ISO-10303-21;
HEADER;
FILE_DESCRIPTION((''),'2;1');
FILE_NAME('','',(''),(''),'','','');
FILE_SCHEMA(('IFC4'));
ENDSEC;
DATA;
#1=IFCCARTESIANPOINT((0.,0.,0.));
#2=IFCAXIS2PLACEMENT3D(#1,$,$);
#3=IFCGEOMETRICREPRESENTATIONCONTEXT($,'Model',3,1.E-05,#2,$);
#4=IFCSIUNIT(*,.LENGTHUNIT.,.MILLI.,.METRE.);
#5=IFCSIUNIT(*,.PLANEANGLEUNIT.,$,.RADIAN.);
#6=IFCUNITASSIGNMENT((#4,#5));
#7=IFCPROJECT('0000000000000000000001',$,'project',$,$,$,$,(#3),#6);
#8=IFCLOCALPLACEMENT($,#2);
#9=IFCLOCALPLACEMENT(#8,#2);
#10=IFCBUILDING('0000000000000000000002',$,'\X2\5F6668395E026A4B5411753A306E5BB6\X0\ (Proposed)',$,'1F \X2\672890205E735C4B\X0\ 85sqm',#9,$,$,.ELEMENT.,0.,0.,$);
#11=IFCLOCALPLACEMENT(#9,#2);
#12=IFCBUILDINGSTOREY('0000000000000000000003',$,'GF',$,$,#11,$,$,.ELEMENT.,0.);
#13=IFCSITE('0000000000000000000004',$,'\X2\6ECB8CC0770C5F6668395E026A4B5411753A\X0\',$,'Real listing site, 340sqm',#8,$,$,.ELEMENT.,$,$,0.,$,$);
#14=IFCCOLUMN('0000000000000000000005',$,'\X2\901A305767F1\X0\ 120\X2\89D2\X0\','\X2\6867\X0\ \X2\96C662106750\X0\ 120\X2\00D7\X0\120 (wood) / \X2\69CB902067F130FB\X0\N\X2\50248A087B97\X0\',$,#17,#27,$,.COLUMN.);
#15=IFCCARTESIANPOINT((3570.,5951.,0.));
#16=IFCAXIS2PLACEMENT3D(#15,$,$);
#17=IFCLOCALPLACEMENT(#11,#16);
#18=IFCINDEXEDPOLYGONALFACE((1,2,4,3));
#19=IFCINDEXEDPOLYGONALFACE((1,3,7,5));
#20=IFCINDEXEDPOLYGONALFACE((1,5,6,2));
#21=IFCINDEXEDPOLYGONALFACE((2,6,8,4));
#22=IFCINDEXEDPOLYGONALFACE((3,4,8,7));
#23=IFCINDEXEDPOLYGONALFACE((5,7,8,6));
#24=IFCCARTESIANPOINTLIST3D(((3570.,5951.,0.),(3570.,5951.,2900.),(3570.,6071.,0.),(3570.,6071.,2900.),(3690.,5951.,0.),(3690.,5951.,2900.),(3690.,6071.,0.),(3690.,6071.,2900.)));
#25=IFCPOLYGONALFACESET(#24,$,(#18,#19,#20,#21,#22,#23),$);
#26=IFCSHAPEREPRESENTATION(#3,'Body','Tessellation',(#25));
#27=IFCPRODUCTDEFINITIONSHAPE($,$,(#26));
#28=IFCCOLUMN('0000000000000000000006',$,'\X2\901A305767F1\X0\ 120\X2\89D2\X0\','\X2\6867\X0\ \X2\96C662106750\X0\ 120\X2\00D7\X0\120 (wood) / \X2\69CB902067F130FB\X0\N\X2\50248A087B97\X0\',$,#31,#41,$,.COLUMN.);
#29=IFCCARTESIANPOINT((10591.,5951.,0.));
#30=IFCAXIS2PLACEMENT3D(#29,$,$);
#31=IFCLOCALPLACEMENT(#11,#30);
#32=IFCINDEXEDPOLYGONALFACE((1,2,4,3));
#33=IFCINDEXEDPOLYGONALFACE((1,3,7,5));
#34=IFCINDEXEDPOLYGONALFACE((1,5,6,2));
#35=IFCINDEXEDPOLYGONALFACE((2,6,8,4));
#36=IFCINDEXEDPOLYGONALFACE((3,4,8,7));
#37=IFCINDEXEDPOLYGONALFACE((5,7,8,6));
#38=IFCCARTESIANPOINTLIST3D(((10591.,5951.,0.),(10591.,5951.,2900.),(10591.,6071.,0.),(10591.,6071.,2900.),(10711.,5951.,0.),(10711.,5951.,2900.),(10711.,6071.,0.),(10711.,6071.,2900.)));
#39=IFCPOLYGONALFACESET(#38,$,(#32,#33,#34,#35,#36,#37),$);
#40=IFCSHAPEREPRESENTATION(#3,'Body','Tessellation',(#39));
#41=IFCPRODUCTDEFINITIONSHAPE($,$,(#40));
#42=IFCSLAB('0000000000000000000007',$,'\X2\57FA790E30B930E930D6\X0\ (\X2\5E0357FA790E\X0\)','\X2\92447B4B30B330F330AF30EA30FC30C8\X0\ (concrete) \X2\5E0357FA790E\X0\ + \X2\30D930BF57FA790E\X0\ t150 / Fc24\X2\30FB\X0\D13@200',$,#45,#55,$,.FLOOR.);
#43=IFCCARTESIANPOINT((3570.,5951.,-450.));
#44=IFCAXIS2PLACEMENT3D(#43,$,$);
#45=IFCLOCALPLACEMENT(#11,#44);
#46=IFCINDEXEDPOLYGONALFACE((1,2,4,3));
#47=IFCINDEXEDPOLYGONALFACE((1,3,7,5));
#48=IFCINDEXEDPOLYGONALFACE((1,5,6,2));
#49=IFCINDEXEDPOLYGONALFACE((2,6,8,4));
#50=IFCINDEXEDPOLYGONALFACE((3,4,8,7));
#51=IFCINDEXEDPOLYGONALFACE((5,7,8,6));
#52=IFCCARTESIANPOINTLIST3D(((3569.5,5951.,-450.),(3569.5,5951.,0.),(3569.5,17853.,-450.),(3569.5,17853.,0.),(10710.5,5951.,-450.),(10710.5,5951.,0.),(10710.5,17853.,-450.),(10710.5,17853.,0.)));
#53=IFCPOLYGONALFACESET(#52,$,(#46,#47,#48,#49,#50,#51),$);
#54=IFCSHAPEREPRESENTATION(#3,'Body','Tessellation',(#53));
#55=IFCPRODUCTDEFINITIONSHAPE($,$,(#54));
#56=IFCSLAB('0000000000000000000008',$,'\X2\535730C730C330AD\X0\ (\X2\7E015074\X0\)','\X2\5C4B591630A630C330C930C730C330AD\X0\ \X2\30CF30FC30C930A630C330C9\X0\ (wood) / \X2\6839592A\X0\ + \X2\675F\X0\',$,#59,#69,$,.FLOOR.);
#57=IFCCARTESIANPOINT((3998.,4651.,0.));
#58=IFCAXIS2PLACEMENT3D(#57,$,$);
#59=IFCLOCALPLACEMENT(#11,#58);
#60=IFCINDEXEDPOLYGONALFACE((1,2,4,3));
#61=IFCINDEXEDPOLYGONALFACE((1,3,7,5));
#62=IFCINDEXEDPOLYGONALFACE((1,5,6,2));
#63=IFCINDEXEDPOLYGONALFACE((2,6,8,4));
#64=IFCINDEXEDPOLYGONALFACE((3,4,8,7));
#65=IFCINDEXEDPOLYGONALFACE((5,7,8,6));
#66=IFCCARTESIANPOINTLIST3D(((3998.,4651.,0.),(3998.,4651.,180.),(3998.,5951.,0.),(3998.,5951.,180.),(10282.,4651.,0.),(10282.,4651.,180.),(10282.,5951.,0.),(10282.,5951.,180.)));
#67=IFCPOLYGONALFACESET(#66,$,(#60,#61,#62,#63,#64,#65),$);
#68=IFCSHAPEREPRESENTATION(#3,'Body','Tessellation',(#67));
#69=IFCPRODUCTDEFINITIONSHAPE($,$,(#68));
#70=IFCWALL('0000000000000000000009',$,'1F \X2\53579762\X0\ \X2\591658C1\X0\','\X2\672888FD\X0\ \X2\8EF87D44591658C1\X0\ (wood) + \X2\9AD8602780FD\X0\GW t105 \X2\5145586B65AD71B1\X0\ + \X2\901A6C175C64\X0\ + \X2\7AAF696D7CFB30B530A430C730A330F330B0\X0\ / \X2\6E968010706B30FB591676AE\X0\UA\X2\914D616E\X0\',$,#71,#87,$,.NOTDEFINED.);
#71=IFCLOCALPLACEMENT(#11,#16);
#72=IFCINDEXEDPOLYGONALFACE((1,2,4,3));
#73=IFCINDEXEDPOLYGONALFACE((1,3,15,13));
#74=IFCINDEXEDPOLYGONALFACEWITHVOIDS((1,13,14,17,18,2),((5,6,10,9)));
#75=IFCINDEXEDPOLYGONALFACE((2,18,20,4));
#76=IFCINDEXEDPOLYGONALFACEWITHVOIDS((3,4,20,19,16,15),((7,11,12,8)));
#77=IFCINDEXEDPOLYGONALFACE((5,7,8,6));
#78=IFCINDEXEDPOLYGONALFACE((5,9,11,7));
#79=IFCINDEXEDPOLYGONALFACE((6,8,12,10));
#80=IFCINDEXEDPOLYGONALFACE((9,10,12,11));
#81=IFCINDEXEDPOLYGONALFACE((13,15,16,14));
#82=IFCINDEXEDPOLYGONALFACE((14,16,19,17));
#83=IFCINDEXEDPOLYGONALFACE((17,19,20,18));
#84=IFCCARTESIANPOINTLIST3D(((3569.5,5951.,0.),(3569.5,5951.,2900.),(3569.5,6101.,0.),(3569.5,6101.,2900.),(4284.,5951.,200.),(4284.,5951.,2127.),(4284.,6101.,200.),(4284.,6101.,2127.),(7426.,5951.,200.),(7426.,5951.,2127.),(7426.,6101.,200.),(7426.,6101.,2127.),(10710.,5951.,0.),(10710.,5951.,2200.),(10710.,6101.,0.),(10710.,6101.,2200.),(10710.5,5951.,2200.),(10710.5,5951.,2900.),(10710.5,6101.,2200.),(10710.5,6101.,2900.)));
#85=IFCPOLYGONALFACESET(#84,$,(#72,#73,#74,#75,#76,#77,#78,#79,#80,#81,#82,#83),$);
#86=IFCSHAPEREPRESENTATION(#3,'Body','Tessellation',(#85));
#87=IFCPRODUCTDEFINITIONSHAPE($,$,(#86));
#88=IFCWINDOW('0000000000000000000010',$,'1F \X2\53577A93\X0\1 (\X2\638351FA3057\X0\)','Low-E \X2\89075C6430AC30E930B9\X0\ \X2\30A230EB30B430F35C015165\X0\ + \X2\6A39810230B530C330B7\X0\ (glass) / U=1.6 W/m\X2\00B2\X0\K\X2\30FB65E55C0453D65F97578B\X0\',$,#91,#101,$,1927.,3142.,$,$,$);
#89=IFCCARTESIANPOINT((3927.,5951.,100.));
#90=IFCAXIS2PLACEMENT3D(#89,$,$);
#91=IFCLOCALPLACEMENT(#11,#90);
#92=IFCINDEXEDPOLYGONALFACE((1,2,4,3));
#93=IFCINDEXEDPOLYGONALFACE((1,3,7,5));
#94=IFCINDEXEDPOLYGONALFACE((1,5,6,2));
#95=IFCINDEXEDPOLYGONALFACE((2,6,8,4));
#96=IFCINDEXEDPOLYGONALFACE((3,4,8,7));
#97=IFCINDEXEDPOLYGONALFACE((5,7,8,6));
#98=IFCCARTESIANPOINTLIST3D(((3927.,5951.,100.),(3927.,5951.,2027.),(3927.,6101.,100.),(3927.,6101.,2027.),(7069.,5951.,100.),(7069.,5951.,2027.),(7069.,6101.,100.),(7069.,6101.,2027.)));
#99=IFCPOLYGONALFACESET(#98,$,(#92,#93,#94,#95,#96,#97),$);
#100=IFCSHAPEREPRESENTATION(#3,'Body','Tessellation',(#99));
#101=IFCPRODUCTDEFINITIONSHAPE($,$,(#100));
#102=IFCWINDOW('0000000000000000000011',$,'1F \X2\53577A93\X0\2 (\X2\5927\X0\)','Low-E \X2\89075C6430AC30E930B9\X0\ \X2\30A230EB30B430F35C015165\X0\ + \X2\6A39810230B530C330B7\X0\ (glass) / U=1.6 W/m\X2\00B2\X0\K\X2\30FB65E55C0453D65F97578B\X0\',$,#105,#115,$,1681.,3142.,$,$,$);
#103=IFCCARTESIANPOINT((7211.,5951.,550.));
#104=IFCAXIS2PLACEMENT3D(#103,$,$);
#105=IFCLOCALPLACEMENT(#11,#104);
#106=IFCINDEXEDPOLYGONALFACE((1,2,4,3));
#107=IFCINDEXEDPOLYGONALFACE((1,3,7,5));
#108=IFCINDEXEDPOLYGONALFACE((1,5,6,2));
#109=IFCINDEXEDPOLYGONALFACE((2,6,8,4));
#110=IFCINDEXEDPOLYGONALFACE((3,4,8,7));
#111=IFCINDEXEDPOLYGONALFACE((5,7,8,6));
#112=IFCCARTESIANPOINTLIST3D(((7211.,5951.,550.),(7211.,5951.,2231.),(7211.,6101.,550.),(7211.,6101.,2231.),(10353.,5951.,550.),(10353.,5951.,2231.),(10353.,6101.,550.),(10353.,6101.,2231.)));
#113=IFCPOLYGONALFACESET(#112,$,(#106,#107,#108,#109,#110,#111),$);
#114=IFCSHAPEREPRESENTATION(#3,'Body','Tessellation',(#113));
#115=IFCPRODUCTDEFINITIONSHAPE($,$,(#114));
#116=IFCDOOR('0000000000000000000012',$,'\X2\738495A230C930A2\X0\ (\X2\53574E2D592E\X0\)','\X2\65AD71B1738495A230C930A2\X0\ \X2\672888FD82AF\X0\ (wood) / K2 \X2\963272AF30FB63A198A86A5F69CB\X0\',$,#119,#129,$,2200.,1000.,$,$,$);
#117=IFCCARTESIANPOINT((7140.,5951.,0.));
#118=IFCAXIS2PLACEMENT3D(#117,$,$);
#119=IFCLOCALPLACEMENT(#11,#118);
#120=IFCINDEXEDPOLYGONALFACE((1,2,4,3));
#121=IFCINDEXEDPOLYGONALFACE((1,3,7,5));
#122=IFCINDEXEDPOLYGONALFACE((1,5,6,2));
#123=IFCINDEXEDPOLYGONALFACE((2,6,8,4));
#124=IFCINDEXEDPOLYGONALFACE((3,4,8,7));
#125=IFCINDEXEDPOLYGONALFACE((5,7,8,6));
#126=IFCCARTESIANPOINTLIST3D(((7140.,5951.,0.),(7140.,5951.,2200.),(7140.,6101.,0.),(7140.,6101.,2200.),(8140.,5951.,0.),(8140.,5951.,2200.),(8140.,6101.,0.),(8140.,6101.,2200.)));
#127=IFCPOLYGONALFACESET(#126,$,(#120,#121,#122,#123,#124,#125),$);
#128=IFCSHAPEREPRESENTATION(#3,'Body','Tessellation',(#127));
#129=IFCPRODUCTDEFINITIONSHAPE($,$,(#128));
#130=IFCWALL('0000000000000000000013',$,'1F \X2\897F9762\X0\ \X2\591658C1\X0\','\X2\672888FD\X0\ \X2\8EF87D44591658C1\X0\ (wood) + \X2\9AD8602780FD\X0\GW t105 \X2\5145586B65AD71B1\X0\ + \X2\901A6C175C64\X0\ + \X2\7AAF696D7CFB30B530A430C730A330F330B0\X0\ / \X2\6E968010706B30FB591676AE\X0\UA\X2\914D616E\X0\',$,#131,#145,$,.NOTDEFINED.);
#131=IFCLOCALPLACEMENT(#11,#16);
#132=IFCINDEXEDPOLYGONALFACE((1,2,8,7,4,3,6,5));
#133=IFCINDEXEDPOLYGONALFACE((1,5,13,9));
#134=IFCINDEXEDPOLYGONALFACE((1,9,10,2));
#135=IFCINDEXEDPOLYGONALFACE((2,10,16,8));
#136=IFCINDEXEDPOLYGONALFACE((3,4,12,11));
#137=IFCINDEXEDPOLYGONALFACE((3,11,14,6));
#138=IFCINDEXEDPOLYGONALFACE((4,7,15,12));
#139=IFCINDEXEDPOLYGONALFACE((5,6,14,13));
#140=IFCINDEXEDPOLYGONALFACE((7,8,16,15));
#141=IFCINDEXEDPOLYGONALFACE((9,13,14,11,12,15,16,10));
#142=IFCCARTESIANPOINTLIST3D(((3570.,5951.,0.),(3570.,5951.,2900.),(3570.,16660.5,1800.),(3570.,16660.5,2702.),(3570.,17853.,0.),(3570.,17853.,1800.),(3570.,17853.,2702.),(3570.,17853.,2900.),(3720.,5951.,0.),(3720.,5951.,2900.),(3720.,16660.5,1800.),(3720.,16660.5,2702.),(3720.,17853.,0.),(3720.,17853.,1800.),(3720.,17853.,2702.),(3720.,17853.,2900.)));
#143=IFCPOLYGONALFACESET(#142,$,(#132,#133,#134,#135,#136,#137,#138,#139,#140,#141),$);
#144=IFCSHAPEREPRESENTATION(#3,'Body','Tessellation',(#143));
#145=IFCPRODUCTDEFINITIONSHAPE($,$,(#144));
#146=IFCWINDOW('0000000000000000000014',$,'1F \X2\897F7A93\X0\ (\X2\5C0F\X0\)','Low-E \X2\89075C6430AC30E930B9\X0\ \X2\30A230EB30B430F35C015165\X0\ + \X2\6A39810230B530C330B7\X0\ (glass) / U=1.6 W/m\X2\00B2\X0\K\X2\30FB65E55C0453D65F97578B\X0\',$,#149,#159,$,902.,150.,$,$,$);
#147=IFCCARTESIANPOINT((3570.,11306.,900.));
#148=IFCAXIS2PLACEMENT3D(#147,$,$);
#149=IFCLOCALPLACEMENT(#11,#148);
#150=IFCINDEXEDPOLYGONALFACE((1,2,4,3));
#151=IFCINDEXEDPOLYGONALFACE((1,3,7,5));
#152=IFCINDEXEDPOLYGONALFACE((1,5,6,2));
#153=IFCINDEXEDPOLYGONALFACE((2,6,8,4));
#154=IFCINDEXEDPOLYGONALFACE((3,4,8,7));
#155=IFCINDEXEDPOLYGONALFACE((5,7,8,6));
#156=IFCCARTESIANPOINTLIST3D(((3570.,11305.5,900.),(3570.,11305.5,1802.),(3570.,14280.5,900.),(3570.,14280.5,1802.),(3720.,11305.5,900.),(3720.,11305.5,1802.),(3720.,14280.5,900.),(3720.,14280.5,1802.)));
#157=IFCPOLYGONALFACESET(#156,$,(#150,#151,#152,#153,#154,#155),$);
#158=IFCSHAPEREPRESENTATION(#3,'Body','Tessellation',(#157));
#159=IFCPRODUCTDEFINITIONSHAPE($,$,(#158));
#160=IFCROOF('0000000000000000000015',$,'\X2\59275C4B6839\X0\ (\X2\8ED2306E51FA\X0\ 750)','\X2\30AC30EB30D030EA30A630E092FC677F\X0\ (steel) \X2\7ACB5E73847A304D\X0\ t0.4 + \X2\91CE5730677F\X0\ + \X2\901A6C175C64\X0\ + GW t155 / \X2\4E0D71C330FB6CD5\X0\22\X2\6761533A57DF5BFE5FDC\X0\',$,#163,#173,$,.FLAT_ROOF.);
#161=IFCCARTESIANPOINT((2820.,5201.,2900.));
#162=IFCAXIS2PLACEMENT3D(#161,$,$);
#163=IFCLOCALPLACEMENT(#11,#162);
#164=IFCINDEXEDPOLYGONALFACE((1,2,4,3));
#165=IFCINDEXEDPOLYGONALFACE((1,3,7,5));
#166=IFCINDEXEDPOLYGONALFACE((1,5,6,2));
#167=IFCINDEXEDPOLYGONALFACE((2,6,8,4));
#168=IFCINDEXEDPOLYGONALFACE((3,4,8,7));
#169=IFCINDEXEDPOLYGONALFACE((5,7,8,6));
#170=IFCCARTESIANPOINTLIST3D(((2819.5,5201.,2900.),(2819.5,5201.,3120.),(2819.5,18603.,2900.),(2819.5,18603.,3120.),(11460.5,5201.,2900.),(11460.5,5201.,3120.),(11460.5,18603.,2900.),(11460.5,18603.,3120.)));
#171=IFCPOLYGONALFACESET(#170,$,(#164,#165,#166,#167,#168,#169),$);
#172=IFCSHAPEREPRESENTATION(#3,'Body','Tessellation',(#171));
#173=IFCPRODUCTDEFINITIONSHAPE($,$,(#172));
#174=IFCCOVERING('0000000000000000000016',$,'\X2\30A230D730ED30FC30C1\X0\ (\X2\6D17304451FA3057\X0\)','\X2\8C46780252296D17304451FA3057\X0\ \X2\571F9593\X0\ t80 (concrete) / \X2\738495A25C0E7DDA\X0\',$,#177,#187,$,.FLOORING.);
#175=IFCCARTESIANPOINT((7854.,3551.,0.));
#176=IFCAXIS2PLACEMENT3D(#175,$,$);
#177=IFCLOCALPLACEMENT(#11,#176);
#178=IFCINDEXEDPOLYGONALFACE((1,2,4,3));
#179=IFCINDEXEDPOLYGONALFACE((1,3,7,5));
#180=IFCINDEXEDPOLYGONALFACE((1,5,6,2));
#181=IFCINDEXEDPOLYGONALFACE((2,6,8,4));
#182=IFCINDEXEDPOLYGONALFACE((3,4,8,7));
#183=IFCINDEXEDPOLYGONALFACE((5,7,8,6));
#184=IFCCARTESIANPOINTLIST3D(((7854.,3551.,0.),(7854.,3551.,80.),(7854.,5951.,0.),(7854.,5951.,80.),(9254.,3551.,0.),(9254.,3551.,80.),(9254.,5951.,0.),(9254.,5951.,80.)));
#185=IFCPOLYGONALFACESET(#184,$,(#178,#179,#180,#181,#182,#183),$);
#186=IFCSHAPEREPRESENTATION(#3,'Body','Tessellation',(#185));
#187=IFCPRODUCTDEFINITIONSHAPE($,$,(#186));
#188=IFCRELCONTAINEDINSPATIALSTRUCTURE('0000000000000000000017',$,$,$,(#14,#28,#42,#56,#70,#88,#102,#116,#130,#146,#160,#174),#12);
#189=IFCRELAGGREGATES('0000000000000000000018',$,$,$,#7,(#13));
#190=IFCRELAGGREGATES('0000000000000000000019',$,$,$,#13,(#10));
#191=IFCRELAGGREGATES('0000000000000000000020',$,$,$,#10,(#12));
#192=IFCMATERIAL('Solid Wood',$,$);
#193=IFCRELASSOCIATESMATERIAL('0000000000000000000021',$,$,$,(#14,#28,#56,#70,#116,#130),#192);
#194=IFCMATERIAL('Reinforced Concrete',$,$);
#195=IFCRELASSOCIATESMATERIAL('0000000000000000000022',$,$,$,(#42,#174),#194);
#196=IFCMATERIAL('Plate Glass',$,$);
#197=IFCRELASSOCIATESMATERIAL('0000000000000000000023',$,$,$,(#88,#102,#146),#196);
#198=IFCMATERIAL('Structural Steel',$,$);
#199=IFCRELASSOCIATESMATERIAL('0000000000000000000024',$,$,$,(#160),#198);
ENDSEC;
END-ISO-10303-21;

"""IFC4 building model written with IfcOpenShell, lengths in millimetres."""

from ifc_helpers import new_model, si_unit, frame, frame_2d, origin, place, context, project, spatial, rectangle, extrude, material, element, fill, save


model = new_model("IFC4")

# Units and contexts
model_context = context("Model", 3, precision=1e-05, world=origin())
ifc_project = project(units=[si_unit("LENGTHUNIT", "METRE", prefix="MILLI"), si_unit("PLANEANGLEUNIT", "RADIAN")], contexts=[model_context])

# Site, building, storey
site_placement = place(None, origin())
site = spatial("IfcSite", under=ifc_project, at=site_placement, Name="滋賀県彦根市橋向町", ObjectType="Real listing site, 340sqm", CompositionType="ELEMENT", RefElevation=0.0)
building_placement = place(site_placement, origin())
building = spatial("IfcBuilding", under=site, at=building_placement, Name="彦根市橋向町の家 (Proposed)", ObjectType="1F 木造平屋 85sqm", CompositionType="ELEMENT", ElevationOfRefHeight=0.0, ElevationOfTerrain=0.0)
storey_placement = place(building_placement, origin())
storey = spatial("IfcBuildingStorey", under=building, at=storey_placement, Name="GF", CompositionType="ELEMENT", Elevation=0.0)

# Columns
ifc_material_1 = material(Name="Solid Wood")
column_1_placement = place(storey_placement, frame((3570.0, 5951.0, 0.0)))
element("IfcColumn", 1, at=column_1_placement, inside=storey, material=ifc_material_1, Name="通し柱 120角", Description="桧 集成材 120×120 (wood) / 構造柱・N値計算", PredefinedType="COLUMN", context=model_context, shape_type="SweptSolid", body=[
    extrude(rectangle(XDim=120.0, YDim=120.0, at=frame_2d((60.0, 60.0))), frame((3570.0, 5951.0, 0.0)), (0.0, 0.0, 1.0), 2900.0),
])
column_2_placement = place(storey_placement, frame((10591.0, 5951.0, 0.0)))
element("IfcColumn", 2, at=column_2_placement, inside=storey, material=ifc_material_1, Name="通し柱 120角", Description="桧 集成材 120×120 (wood) / 構造柱・N値計算", PredefinedType="COLUMN", context=model_context, shape_type="SweptSolid", body=[
    extrude(rectangle(XDim=120.0, YDim=120.0, at=frame_2d((60.0, 60.0))), frame((10591.0, 5951.0, 0.0)), (0.0, 0.0, 1.0), 2900.0),
])

# Slabs
ifc_material_2 = material(Name="Reinforced Concrete")
slab_1_placement = place(storey_placement, frame((3570.0, 5951.0, -450.0)))
element("IfcSlab", 3, at=slab_1_placement, inside=storey, material=ifc_material_2, Name="基礎スラブ (布基礎)", Description="鉄筋コンクリート (concrete) 布基礎 + ベタ基礎 t150 / Fc24・D13@200", PredefinedType="FLOOR", context=model_context, shape_type="SweptSolid", body=[
    extrude(rectangle(XDim=7141.0, YDim=11902.0, at=frame_2d((3570.0, 5951.0))), frame((3570.0, 5951.0, -450.0)), (0.0, 0.0, 1.0), 450.0),
])
slab_2_placement = place(storey_placement, frame((3998.0, 4651.0, 0.0)))
element("IfcSlab", 4, at=slab_2_placement, inside=storey, material=ifc_material_1, Name="南デッキ (縁側)", Description="屋外ウッドデッキ ハードウッド (wood) / 根太 + 束", PredefinedType="FLOOR", context=model_context, shape_type="SweptSolid", body=[
    extrude(rectangle(XDim=6284.0, YDim=1300.0, at=frame_2d((3142.0, 650.0))), frame((3998.0, 4651.0, 0.0)), (0.0, 0.0, 1.0), 180.0),
])

# Wall, openings, windows, door
wall_1_placement = place(storey_placement, frame((3570.0, 5951.0, 0.0)))
wall_1 = element("IfcWall", 5, at=wall_1_placement, inside=storey, material=ifc_material_1, Name="1F 南面 外壁", Description="木製 軸組外壁 (wood) + 高性能GW t105 充填断熱 + 通気層 + 窯業系サイディング / 準耐火・外皮UA配慮", PredefinedType="NOTDEFINED", context=model_context, shape_type="SweptSolid", body=[
    extrude(rectangle(XDim=7141.0, YDim=150.0, at=frame_2d((3570.0, 75.0))), frame((3570.0, 5951.0, 0.0)), (0.0, 0.0, 1.0), 2900.0),
])
opening_1_placement = place(storey_placement, frame((3927.0, 5951.0, 100.0)))
opening_1 = element("IfcOpeningElement", 6, at=opening_1_placement, cuts=wall_1, PredefinedType="NOTDEFINED", context=model_context, shape_type="SweptSolid", body=[
    extrude(rectangle(XDim=3142.0, YDim=150.0, at=frame_2d((1571.0, 75.0))), frame((3927.0, 5951.0, 100.0)), (0.0, 0.0, 1.0), 1927.0),
])
opening_2_placement = place(storey_placement, frame((7211.0, 5951.0, 550.0)))
opening_2 = element("IfcOpeningElement", 7, at=opening_2_placement, cuts=wall_1, PredefinedType="NOTDEFINED", context=model_context, shape_type="SweptSolid", body=[
    extrude(rectangle(XDim=3142.0, YDim=150.0, at=frame_2d((1571.0, 75.0))), frame((7211.0, 5951.0, 550.0)), (0.0, 0.0, 1.0), 1681.0),
])
opening_3_placement = place(storey_placement, frame((7140.0, 5951.0, 0.0)))
opening_3 = element("IfcOpeningElement", 8, at=opening_3_placement, cuts=wall_1, PredefinedType="NOTDEFINED", context=model_context, shape_type="SweptSolid", body=[
    extrude(rectangle(XDim=1000.0, YDim=150.0, at=frame_2d((500.0, 75.0))), frame((7140.0, 5951.0, 0.0)), (0.0, 0.0, 1.0), 2200.0),
])
ifc_material_3 = material(Name="Plate Glass")
window_1_placement = place(storey_placement, frame((3927.0, 5951.0, 100.0)))
window_1 = element("IfcWindow", 9, at=window_1_placement, inside=storey, material=ifc_material_3, Name="1F 南窓1 (掃出し)", Description="Low-E 複層ガラス アルゴン封入 + 樹脂サッシ (glass) / U=1.6 W/m²K・日射取得型", OverallHeight=1927.0, OverallWidth=3142.0, context=model_context, shape_type="SweptSolid", body=[
    extrude(rectangle(XDim=3142.0, YDim=150.0, at=frame_2d((1571.0, 75.0))), frame((3927.0, 5951.0, 100.0)), (0.0, 0.0, 1.0), 1927.0),
])
fill(opening_1, window_1)
window_2_placement = place(storey_placement, frame((7211.0, 5951.0, 550.0)))
window_2 = element("IfcWindow", 10, at=window_2_placement, inside=storey, material=ifc_material_3, Name="1F 南窓2 (大)", Description="Low-E 複層ガラス アルゴン封入 + 樹脂サッシ (glass) / U=1.6 W/m²K・日射取得型", OverallHeight=1681.0, OverallWidth=3142.0, context=model_context, shape_type="SweptSolid", body=[
    extrude(rectangle(XDim=3142.0, YDim=150.0, at=frame_2d((1571.0, 75.0))), frame((7211.0, 5951.0, 550.0)), (0.0, 0.0, 1.0), 1681.0),
])
fill(opening_2, window_2)
door_placement = place(storey_placement, frame((7140.0, 5951.0, 0.0)))
door = element("IfcDoor", 11, at=door_placement, inside=storey, material=ifc_material_1, Name="玄関ドア (南中央)", Description="断熱玄関ドア 木製芯 (wood) / K2 防犯・採風機構", OverallHeight=2200.0, OverallWidth=1000.0, context=model_context, shape_type="SweptSolid", body=[
    extrude(rectangle(XDim=1000.0, YDim=150.0, at=frame_2d((500.0, 75.0))), frame((7140.0, 5951.0, 0.0)), (0.0, 0.0, 1.0), 2200.0),
])
fill(opening_3, door)

# Wall, opening, window
wall_2_placement = place(storey_placement, frame((3570.0, 5951.0, 0.0)))
wall_2 = element("IfcWall", 12, at=wall_2_placement, inside=storey, material=ifc_material_1, Name="1F 西面 外壁", Description="木製 軸組外壁 (wood) + 高性能GW t105 充填断熱 + 通気層 + 窯業系サイディング / 準耐火・外皮UA配慮", PredefinedType="NOTDEFINED", context=model_context, shape_type="SweptSolid", body=[
    extrude(rectangle(XDim=150.0, YDim=11902.0, at=frame_2d((75.0, 5951.0))), frame((3570.0, 5951.0, 0.0)), (0.0, 0.0, 1.0), 2900.0),
])
opening_4_placement = place(storey_placement, frame((3570.0, 11306.0, 900.0)))
opening_4 = element("IfcOpeningElement", 13, at=opening_4_placement, cuts=wall_2, PredefinedType="NOTDEFINED", context=model_context, shape_type="SweptSolid", body=[
    extrude(rectangle(XDim=150.0, YDim=2975.0, at=frame_2d((75.0, 1487.0))), frame((3570.0, 11306.0, 900.0)), (0.0, 0.0, 1.0), 902.0),
])
window_3_placement = place(storey_placement, frame((3570.0, 11306.0, 900.0)))
window_3 = element("IfcWindow", 14, at=window_3_placement, inside=storey, material=ifc_material_3, Name="1F 西窓 (小)", Description="Low-E 複層ガラス アルゴン封入 + 樹脂サッシ (glass) / U=1.6 W/m²K・日射取得型", OverallHeight=902.0, OverallWidth=150.0, context=model_context, shape_type="SweptSolid", body=[
    extrude(rectangle(XDim=150.0, YDim=2975.0, at=frame_2d((75.0, 1487.0))), frame((3570.0, 11306.0, 900.0)), (0.0, 0.0, 1.0), 902.0),
])
fill(opening_4, window_3)

# Roof
ifc_material_4 = material(Name="Structural Steel")
roof_placement = place(storey_placement, frame((2820.0, 5201.0, 2900.0)))
element("IfcRoof", 15, at=roof_placement, inside=storey, material=ifc_material_4, Name="大屋根 (軒の出 750)", Description="ガルバリウム鋼板 (steel) 立平葺き t0.4 + 野地板 + 通気層 + GW t155 / 不燃・法22条区域対応", PredefinedType="FLAT_ROOF", context=model_context, shape_type="SweptSolid", body=[
    extrude(rectangle(XDim=8641.0, YDim=13402.0, at=frame_2d((4320.0, 6701.0))), frame((2820.0, 5201.0, 2900.0)), (0.0, 0.0, 1.0), 220.0),
])

# Covering
covering_1_placement = place(storey_placement, frame((7854.0, 3551.0, 0.0)))
element("IfcCovering", 16, at=covering_1_placement, inside=storey, material=ifc_material_2, Name="アプローチ (洗い出し)", Description="豆砂利洗い出し 土間 t80 (concrete) / 玄関導線", PredefinedType="FLOORING", context=model_context, shape_type="SweptSolid", body=[
    extrude(rectangle(XDim=1400.0, YDim=2400.0, at=frame_2d((700.0, 1200.0))), frame((7854.0, 3551.0, 0.0)), (0.0, 0.0, 1.0), 80.0),
])

save(model, "model.ifc")
